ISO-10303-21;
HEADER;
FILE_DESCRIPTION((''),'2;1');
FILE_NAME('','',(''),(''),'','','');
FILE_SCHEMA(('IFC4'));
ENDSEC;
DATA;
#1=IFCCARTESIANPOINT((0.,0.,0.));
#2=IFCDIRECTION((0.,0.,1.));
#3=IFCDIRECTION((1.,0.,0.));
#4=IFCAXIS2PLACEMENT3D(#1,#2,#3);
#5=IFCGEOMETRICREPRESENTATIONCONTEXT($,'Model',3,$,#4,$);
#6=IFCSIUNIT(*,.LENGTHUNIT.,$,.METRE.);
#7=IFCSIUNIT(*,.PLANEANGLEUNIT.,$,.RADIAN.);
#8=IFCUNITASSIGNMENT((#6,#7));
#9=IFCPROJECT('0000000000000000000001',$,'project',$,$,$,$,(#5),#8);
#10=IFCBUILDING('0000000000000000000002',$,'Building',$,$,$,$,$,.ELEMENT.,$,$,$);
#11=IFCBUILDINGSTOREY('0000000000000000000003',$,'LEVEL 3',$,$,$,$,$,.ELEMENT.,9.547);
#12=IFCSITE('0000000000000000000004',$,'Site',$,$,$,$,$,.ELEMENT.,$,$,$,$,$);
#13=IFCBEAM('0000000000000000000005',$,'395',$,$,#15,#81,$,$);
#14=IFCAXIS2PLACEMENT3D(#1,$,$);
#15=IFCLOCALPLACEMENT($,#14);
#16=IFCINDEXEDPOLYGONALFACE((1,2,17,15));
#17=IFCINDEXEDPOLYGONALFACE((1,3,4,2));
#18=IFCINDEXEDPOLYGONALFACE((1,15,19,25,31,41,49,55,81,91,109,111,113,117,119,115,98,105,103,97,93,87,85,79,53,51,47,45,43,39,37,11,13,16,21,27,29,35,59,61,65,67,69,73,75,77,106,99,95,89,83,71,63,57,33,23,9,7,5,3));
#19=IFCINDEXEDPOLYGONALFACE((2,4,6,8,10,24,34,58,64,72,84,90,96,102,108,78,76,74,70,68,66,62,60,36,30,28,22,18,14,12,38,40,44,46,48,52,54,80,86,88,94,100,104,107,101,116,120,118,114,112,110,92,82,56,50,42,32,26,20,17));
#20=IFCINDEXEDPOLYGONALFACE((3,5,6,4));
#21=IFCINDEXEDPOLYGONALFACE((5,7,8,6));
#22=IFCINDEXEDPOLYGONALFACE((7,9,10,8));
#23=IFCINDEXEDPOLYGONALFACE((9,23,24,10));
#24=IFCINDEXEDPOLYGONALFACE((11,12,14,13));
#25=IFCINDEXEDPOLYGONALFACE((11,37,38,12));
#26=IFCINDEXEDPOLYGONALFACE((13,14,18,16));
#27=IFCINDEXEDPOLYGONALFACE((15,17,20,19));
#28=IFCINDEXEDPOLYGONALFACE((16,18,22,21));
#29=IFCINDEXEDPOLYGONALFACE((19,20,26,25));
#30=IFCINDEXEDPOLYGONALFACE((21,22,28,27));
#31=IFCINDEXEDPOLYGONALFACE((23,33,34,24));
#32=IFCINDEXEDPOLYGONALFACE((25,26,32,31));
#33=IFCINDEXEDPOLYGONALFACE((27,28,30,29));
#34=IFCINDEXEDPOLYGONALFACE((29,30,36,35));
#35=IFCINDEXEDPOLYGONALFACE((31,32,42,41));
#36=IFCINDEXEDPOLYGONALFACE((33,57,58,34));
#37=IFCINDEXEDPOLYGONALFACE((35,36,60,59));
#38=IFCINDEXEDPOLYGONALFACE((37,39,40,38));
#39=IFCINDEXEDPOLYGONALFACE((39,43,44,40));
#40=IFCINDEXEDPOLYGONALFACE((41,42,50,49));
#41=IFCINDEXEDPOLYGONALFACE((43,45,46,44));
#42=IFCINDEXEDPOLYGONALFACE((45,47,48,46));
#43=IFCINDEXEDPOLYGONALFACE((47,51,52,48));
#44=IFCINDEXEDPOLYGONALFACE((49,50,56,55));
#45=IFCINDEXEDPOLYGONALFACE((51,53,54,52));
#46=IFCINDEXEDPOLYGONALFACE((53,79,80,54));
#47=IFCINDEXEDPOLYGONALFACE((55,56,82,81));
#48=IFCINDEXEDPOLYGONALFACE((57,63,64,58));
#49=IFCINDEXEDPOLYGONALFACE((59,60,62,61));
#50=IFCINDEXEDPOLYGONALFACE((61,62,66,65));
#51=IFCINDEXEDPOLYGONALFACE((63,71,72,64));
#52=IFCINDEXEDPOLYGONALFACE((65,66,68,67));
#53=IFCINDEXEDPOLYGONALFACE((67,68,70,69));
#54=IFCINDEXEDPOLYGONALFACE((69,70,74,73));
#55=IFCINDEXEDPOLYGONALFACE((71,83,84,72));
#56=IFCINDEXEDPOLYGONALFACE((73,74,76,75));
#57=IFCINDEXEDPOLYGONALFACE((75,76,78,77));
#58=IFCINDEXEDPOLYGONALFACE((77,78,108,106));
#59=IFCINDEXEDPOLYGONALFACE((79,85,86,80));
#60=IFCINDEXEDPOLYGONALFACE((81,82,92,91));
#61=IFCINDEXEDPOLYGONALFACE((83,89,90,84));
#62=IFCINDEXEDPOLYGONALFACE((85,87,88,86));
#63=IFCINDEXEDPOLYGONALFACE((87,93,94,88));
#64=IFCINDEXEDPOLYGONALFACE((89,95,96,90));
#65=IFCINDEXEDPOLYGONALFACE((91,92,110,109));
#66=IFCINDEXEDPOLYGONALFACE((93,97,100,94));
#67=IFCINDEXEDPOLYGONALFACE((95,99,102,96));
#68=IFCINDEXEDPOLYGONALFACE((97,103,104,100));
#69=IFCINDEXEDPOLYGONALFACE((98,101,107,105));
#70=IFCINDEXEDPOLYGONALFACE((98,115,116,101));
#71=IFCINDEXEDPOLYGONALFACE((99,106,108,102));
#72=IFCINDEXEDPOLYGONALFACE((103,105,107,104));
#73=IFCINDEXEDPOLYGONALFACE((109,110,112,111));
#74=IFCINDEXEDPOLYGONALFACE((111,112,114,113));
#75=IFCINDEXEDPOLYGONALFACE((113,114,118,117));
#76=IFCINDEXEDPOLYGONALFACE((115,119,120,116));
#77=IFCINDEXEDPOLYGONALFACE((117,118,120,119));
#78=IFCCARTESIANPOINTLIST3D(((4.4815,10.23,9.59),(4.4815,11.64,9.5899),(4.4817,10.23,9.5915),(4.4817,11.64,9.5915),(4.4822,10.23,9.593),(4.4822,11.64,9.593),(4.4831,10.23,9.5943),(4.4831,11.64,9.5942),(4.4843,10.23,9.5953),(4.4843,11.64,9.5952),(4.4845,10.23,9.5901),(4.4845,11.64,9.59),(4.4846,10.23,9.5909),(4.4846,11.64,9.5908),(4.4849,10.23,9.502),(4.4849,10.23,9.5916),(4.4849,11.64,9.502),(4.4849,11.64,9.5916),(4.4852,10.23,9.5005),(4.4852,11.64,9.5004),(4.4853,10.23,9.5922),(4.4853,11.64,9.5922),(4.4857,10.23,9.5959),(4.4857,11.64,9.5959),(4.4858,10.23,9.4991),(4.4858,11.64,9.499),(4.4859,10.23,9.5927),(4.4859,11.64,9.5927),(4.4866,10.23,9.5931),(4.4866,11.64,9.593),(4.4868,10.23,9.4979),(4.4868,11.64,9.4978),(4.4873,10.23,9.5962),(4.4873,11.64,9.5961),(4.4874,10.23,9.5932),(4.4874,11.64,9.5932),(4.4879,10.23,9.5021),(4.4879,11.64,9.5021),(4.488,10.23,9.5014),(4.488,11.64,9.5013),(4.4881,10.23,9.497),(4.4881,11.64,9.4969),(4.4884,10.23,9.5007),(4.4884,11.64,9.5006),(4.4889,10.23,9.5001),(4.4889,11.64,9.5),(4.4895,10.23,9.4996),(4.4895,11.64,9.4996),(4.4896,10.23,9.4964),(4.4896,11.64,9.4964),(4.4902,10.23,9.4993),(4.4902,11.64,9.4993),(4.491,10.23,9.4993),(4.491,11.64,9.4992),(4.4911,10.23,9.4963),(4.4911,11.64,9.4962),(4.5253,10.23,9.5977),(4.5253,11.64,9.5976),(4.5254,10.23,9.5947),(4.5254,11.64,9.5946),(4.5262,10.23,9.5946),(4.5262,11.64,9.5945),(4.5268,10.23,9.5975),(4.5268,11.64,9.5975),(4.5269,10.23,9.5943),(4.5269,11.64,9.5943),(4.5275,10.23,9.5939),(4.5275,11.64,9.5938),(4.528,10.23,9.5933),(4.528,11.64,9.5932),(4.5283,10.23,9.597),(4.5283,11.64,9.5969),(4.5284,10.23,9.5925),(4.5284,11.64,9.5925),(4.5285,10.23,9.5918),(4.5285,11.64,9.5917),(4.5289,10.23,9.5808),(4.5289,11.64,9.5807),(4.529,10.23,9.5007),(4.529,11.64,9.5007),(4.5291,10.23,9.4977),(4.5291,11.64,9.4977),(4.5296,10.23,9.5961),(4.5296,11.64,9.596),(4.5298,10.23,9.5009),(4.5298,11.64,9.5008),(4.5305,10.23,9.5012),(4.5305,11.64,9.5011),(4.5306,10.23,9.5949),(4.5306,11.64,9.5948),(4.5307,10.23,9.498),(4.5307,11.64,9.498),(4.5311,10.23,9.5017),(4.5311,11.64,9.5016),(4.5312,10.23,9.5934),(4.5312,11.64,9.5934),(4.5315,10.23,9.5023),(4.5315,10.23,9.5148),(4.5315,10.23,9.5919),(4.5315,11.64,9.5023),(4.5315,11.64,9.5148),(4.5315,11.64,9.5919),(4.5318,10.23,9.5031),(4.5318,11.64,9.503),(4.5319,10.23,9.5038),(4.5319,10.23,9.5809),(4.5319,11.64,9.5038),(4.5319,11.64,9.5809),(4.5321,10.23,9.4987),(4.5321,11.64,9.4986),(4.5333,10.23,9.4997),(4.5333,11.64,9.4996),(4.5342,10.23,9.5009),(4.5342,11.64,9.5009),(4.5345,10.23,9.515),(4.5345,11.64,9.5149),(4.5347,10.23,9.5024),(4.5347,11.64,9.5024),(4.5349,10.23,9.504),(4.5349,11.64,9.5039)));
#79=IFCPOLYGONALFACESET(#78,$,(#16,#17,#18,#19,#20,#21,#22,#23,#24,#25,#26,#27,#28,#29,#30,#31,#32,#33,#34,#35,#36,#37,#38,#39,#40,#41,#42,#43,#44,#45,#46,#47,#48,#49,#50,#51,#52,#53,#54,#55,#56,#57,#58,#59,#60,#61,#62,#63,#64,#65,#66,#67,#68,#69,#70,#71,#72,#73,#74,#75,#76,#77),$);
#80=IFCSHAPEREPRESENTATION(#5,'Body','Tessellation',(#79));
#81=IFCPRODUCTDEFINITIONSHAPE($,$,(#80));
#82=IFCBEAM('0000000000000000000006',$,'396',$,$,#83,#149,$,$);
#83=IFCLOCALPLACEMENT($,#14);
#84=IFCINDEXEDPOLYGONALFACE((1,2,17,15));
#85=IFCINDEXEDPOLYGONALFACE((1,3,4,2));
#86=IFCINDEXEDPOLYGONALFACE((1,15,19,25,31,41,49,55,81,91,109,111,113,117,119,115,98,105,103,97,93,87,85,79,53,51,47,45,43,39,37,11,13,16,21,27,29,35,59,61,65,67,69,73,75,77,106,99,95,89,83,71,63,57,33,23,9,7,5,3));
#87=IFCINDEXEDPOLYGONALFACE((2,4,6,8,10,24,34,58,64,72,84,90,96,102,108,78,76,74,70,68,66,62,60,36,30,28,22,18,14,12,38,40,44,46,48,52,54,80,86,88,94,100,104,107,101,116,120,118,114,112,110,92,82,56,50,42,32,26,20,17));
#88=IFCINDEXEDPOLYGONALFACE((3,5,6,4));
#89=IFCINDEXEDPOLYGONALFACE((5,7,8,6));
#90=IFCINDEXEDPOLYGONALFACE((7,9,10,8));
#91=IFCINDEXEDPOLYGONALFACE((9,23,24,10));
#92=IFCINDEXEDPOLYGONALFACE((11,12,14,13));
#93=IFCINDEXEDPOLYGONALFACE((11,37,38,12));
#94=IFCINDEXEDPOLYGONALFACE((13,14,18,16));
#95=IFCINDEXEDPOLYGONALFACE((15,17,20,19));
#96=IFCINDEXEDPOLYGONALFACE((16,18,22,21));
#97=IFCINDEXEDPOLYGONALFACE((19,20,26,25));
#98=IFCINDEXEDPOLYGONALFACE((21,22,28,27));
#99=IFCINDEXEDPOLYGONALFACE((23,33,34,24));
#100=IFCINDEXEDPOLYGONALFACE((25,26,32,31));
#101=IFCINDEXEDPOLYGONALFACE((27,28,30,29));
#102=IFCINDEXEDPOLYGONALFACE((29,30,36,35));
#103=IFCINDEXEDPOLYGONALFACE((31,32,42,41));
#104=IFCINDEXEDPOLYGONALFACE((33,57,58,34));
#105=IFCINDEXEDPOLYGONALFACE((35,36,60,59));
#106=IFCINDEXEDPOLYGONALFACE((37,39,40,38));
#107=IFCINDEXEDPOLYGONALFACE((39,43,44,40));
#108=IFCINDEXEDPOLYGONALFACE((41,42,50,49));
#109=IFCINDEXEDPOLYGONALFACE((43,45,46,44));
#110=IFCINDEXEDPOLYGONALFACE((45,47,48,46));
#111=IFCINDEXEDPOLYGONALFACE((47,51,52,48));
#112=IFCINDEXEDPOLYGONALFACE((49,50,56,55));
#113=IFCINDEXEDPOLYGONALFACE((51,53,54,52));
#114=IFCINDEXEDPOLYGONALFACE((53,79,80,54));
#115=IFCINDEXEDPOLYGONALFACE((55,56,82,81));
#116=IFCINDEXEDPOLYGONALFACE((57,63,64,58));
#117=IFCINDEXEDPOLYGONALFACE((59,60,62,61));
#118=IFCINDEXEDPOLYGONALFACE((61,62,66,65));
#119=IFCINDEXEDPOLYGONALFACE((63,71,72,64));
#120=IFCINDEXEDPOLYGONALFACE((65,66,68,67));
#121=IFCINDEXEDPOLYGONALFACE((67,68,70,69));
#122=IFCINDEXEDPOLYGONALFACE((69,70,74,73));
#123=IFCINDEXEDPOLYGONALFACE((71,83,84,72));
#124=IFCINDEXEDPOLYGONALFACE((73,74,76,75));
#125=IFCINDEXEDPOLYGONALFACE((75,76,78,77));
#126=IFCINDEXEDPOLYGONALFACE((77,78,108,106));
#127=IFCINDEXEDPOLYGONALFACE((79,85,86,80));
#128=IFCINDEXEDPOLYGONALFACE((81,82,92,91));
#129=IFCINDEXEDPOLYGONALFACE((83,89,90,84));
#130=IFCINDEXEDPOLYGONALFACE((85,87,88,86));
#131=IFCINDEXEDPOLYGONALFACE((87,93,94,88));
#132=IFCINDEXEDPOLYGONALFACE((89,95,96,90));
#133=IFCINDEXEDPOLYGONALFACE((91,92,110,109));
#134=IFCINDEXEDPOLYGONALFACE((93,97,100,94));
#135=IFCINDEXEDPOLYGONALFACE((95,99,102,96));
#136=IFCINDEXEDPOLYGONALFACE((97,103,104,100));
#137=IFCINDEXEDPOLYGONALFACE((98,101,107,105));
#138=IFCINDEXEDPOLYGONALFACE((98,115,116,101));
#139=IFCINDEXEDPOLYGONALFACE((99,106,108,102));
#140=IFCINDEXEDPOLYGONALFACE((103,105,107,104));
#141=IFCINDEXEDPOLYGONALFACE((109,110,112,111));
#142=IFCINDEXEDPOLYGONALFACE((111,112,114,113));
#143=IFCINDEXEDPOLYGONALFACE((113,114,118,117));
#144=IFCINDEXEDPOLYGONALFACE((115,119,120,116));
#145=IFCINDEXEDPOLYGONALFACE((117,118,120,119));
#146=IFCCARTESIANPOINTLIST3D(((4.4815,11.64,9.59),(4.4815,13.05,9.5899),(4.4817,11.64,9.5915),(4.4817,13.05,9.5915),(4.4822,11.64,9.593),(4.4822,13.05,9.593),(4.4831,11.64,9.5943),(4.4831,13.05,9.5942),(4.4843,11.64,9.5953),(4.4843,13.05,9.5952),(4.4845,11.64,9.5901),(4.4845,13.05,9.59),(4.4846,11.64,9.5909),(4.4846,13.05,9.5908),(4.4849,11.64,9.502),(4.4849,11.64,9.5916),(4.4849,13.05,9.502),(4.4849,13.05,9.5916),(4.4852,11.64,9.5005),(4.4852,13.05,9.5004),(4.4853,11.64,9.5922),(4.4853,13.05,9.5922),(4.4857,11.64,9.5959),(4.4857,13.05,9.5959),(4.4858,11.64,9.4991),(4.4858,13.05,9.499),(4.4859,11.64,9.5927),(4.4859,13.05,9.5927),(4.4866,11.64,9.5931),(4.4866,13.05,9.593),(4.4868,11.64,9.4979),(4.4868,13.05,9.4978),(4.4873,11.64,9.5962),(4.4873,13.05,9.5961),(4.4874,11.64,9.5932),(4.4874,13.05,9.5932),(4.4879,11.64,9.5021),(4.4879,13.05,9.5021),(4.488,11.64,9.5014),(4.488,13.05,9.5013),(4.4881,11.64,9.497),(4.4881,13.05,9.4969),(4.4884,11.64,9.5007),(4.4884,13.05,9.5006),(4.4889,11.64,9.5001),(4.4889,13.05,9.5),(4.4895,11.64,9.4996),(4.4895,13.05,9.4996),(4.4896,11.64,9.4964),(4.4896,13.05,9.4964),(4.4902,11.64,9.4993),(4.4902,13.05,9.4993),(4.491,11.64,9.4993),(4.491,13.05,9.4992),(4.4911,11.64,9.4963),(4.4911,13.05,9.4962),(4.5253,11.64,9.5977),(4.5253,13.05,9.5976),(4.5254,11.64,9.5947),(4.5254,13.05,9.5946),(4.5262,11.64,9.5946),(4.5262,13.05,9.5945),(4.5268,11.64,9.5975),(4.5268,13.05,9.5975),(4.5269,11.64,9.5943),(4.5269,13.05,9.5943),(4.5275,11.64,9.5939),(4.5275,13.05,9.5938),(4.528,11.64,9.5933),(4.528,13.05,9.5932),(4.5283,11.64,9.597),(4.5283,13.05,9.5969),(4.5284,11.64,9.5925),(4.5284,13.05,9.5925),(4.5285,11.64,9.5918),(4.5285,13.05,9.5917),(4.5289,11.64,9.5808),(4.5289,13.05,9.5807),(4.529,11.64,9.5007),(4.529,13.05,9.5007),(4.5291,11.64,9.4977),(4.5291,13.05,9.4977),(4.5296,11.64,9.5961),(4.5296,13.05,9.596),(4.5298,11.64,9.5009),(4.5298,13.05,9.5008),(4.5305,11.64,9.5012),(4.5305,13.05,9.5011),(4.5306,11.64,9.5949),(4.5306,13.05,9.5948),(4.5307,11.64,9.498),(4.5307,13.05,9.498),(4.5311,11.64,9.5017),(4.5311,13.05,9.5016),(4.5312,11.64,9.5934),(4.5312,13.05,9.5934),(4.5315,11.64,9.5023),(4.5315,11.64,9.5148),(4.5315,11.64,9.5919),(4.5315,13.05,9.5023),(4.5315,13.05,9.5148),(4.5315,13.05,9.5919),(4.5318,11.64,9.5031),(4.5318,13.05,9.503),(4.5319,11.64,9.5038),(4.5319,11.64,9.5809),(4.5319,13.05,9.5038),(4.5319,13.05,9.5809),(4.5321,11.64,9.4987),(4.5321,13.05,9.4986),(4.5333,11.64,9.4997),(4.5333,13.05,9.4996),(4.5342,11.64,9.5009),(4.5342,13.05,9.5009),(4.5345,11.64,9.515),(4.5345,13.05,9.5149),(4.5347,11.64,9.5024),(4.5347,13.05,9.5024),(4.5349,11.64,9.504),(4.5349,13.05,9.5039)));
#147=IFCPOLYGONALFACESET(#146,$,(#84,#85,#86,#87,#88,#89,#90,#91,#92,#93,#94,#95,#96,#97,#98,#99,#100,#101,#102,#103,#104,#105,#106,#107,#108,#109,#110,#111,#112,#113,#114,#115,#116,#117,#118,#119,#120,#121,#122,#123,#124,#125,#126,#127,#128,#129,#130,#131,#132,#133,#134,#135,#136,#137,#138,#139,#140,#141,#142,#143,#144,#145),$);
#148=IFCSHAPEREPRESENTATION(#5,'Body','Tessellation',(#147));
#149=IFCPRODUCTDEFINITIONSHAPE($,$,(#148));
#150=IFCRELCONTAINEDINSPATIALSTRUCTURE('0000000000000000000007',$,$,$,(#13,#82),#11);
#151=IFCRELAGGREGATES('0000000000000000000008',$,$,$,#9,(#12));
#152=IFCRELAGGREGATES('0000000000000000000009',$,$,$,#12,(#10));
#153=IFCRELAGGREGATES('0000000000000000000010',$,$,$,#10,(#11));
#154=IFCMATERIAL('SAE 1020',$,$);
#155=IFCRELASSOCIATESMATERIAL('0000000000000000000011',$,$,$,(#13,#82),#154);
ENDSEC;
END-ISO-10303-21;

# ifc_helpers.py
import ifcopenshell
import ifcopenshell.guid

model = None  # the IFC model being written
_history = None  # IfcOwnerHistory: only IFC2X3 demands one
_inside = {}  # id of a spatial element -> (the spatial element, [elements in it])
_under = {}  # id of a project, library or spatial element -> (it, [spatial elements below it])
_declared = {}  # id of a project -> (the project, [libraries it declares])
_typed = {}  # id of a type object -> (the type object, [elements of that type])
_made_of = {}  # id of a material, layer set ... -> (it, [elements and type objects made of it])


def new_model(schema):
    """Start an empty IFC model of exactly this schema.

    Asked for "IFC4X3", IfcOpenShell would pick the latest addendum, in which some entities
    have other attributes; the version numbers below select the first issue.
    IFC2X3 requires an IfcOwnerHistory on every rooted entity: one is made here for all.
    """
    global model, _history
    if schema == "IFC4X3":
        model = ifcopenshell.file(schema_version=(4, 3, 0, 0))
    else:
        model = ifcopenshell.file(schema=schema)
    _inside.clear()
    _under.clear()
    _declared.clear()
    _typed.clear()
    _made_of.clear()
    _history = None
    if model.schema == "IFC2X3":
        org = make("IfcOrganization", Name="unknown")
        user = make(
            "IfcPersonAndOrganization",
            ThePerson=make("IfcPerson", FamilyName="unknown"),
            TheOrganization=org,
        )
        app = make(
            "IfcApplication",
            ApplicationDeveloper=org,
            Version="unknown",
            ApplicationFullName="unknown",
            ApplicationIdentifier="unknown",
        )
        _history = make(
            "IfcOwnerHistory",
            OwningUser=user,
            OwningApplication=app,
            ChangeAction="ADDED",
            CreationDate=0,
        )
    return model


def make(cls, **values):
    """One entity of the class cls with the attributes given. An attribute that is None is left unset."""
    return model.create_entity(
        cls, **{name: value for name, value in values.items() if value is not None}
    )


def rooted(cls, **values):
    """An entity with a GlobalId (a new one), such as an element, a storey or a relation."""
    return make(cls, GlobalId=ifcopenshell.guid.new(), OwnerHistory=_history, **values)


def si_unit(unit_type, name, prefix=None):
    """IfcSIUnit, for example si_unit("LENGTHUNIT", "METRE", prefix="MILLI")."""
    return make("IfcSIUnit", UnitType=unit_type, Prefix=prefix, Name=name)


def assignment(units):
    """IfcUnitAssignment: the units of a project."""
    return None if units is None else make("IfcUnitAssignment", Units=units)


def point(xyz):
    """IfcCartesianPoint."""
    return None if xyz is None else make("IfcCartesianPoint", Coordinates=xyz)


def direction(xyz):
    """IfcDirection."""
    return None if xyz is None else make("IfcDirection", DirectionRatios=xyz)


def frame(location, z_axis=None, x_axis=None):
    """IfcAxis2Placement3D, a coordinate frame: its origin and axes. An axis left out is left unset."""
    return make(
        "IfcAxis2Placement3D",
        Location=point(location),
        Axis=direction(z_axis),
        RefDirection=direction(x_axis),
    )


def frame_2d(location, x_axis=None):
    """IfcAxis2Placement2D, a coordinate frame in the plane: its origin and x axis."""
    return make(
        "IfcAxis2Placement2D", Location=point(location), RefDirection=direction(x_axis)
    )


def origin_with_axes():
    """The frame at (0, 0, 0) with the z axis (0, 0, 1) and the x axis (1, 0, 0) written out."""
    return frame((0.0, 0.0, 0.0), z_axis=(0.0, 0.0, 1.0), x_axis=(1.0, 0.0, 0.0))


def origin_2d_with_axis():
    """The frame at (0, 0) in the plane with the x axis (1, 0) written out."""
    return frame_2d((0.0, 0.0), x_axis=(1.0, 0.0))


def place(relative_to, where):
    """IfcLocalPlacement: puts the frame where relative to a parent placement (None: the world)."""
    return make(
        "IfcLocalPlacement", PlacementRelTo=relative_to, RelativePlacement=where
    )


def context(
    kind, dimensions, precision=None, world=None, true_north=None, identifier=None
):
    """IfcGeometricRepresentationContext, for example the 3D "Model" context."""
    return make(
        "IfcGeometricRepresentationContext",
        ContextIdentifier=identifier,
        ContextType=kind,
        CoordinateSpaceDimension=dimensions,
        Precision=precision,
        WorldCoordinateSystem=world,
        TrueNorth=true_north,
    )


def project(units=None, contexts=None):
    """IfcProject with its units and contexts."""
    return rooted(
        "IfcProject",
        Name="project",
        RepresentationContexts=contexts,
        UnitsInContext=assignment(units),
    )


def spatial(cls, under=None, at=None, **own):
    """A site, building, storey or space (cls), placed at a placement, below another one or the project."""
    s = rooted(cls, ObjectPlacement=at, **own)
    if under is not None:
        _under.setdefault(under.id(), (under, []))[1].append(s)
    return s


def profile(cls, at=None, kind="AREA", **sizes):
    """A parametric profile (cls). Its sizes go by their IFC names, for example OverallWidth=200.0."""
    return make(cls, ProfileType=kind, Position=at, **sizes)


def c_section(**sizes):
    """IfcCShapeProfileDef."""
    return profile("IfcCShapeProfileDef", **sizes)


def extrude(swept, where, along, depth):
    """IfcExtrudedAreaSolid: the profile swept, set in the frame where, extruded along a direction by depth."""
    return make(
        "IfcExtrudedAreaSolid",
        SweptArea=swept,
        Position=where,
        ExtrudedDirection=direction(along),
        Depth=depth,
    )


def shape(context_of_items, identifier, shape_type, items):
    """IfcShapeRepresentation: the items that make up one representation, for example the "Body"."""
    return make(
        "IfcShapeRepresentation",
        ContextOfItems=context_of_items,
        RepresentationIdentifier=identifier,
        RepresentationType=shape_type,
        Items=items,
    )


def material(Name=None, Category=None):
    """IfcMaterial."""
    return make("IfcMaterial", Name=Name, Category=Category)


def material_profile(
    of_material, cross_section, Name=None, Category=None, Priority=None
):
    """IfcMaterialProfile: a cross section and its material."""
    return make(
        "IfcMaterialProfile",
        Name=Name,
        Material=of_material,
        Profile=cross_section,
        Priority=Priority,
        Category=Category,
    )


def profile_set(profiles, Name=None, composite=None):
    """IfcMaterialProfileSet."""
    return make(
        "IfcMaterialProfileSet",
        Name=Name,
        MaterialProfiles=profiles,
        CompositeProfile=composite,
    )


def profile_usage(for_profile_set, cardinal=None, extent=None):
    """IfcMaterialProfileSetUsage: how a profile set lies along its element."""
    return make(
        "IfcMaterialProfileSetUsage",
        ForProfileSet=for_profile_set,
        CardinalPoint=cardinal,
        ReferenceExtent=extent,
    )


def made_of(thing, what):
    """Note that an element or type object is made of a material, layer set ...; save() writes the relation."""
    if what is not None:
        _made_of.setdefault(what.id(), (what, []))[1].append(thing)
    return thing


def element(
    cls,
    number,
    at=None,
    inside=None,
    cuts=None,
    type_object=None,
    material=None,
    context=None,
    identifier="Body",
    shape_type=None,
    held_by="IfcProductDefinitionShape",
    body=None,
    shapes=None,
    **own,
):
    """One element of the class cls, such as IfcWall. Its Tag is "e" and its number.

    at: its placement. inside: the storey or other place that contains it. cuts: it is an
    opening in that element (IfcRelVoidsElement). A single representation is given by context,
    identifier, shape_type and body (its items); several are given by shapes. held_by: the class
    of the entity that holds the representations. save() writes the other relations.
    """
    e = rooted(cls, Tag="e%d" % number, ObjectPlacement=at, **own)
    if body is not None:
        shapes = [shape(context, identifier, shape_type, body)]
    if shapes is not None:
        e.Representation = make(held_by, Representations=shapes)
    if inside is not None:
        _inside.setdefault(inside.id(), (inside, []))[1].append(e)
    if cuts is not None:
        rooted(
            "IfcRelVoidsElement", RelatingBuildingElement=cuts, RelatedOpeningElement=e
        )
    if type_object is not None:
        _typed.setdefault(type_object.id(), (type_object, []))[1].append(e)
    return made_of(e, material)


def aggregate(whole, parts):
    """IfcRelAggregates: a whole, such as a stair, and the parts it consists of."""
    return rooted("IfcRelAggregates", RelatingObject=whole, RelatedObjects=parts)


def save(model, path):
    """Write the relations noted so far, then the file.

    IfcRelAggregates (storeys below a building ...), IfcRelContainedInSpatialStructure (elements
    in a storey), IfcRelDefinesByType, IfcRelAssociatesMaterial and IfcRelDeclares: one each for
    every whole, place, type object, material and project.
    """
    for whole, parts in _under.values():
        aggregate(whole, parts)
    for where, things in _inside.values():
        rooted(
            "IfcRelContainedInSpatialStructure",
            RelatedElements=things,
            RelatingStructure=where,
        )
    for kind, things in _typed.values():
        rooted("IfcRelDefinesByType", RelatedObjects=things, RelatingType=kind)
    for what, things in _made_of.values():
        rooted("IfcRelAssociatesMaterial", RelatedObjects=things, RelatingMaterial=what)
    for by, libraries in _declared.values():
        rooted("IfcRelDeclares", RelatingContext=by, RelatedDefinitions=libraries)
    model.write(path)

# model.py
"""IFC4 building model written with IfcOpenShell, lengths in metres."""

from ifc_helpers import new_model, si_unit, frame, origin_with_axes, origin_2d_with_axis, place, context, project, spatial, c_section, extrude, material, material_profile, profile_set, profile_usage, element, save


model = new_model("IFC4")

# Units and contexts
model_context = context("Model", 3, world=origin_with_axes())
ifc_project = project(units=[si_unit("LENGTHUNIT", "METRE"), si_unit("PLANEANGLEUNIT", "RADIAN")], contexts=[model_context])

# Site, building, storey
site = spatial("IfcSite", under=ifc_project, Name="Site", CompositionType="ELEMENT")
building = spatial("IfcBuilding", under=site, Name="Building", CompositionType="ELEMENT")
storey = spatial("IfcBuildingStorey", under=building, Name="LEVEL 3", CompositionType="ELEMENT", Elevation=9.547)

# Beams
ifc_material = material(Name="SAE 1020")
ifc_material_profile_1 = material_profile(ifc_material, c_section(Depth=0.1, Width=0.05, WallThickness=0.003, Girth=0.017, InternalFilletRadius=0.003, at=origin_2d_with_axis()))
ifc_profile_set_1 = profile_set([ifc_material_profile_1])
ifc_profile_usage_1 = profile_usage(ifc_profile_set_1, cardinal=10)
beam_1_placement = place(None, frame((4.5082, 10.23, 9.547), z_axis=(0.0, 1.0, -0.00003), x_axis=(0.999256, 0.000001, 0.038562)))
element("IfcBeam", 1, at=beam_1_placement, inside=storey, material=ifc_profile_usage_1, Name="395", context=model_context, shape_type="SweptSolid", body=[
    extrude(c_section(Depth=0.1, Width=0.05, WallThickness=0.003, Girth=0.017, InternalFilletRadius=0.003, at=origin_2d_with_axis()), origin_with_axes(), (0.0, 0.0, 1.0), 1.41),
])
ifc_material_profile_2 = material_profile(ifc_material, c_section(Depth=0.1, Width=0.05, WallThickness=0.003, Girth=0.017, InternalFilletRadius=0.003, at=origin_2d_with_axis()))
ifc_profile_set_2 = profile_set([ifc_material_profile_2])
ifc_profile_usage_2 = profile_usage(ifc_profile_set_2, cardinal=10)
beam_2_placement = place(None, frame((4.5082, 11.64, 9.547), z_axis=(0.0, 1.0, -0.00003), x_axis=(0.999256, 0.000001, 0.038562)))
element("IfcBeam", 2, at=beam_2_placement, inside=storey, material=ifc_profile_usage_2, Name="396", context=model_context, shape_type="SweptSolid", body=[
    extrude(c_section(Depth=0.1, Width=0.05, WallThickness=0.003, Girth=0.017, InternalFilletRadius=0.003, at=origin_2d_with_axis()), origin_with_axes(), (0.0, 0.0, 1.0), 1.41),
])

save(model, "model.ifc")
